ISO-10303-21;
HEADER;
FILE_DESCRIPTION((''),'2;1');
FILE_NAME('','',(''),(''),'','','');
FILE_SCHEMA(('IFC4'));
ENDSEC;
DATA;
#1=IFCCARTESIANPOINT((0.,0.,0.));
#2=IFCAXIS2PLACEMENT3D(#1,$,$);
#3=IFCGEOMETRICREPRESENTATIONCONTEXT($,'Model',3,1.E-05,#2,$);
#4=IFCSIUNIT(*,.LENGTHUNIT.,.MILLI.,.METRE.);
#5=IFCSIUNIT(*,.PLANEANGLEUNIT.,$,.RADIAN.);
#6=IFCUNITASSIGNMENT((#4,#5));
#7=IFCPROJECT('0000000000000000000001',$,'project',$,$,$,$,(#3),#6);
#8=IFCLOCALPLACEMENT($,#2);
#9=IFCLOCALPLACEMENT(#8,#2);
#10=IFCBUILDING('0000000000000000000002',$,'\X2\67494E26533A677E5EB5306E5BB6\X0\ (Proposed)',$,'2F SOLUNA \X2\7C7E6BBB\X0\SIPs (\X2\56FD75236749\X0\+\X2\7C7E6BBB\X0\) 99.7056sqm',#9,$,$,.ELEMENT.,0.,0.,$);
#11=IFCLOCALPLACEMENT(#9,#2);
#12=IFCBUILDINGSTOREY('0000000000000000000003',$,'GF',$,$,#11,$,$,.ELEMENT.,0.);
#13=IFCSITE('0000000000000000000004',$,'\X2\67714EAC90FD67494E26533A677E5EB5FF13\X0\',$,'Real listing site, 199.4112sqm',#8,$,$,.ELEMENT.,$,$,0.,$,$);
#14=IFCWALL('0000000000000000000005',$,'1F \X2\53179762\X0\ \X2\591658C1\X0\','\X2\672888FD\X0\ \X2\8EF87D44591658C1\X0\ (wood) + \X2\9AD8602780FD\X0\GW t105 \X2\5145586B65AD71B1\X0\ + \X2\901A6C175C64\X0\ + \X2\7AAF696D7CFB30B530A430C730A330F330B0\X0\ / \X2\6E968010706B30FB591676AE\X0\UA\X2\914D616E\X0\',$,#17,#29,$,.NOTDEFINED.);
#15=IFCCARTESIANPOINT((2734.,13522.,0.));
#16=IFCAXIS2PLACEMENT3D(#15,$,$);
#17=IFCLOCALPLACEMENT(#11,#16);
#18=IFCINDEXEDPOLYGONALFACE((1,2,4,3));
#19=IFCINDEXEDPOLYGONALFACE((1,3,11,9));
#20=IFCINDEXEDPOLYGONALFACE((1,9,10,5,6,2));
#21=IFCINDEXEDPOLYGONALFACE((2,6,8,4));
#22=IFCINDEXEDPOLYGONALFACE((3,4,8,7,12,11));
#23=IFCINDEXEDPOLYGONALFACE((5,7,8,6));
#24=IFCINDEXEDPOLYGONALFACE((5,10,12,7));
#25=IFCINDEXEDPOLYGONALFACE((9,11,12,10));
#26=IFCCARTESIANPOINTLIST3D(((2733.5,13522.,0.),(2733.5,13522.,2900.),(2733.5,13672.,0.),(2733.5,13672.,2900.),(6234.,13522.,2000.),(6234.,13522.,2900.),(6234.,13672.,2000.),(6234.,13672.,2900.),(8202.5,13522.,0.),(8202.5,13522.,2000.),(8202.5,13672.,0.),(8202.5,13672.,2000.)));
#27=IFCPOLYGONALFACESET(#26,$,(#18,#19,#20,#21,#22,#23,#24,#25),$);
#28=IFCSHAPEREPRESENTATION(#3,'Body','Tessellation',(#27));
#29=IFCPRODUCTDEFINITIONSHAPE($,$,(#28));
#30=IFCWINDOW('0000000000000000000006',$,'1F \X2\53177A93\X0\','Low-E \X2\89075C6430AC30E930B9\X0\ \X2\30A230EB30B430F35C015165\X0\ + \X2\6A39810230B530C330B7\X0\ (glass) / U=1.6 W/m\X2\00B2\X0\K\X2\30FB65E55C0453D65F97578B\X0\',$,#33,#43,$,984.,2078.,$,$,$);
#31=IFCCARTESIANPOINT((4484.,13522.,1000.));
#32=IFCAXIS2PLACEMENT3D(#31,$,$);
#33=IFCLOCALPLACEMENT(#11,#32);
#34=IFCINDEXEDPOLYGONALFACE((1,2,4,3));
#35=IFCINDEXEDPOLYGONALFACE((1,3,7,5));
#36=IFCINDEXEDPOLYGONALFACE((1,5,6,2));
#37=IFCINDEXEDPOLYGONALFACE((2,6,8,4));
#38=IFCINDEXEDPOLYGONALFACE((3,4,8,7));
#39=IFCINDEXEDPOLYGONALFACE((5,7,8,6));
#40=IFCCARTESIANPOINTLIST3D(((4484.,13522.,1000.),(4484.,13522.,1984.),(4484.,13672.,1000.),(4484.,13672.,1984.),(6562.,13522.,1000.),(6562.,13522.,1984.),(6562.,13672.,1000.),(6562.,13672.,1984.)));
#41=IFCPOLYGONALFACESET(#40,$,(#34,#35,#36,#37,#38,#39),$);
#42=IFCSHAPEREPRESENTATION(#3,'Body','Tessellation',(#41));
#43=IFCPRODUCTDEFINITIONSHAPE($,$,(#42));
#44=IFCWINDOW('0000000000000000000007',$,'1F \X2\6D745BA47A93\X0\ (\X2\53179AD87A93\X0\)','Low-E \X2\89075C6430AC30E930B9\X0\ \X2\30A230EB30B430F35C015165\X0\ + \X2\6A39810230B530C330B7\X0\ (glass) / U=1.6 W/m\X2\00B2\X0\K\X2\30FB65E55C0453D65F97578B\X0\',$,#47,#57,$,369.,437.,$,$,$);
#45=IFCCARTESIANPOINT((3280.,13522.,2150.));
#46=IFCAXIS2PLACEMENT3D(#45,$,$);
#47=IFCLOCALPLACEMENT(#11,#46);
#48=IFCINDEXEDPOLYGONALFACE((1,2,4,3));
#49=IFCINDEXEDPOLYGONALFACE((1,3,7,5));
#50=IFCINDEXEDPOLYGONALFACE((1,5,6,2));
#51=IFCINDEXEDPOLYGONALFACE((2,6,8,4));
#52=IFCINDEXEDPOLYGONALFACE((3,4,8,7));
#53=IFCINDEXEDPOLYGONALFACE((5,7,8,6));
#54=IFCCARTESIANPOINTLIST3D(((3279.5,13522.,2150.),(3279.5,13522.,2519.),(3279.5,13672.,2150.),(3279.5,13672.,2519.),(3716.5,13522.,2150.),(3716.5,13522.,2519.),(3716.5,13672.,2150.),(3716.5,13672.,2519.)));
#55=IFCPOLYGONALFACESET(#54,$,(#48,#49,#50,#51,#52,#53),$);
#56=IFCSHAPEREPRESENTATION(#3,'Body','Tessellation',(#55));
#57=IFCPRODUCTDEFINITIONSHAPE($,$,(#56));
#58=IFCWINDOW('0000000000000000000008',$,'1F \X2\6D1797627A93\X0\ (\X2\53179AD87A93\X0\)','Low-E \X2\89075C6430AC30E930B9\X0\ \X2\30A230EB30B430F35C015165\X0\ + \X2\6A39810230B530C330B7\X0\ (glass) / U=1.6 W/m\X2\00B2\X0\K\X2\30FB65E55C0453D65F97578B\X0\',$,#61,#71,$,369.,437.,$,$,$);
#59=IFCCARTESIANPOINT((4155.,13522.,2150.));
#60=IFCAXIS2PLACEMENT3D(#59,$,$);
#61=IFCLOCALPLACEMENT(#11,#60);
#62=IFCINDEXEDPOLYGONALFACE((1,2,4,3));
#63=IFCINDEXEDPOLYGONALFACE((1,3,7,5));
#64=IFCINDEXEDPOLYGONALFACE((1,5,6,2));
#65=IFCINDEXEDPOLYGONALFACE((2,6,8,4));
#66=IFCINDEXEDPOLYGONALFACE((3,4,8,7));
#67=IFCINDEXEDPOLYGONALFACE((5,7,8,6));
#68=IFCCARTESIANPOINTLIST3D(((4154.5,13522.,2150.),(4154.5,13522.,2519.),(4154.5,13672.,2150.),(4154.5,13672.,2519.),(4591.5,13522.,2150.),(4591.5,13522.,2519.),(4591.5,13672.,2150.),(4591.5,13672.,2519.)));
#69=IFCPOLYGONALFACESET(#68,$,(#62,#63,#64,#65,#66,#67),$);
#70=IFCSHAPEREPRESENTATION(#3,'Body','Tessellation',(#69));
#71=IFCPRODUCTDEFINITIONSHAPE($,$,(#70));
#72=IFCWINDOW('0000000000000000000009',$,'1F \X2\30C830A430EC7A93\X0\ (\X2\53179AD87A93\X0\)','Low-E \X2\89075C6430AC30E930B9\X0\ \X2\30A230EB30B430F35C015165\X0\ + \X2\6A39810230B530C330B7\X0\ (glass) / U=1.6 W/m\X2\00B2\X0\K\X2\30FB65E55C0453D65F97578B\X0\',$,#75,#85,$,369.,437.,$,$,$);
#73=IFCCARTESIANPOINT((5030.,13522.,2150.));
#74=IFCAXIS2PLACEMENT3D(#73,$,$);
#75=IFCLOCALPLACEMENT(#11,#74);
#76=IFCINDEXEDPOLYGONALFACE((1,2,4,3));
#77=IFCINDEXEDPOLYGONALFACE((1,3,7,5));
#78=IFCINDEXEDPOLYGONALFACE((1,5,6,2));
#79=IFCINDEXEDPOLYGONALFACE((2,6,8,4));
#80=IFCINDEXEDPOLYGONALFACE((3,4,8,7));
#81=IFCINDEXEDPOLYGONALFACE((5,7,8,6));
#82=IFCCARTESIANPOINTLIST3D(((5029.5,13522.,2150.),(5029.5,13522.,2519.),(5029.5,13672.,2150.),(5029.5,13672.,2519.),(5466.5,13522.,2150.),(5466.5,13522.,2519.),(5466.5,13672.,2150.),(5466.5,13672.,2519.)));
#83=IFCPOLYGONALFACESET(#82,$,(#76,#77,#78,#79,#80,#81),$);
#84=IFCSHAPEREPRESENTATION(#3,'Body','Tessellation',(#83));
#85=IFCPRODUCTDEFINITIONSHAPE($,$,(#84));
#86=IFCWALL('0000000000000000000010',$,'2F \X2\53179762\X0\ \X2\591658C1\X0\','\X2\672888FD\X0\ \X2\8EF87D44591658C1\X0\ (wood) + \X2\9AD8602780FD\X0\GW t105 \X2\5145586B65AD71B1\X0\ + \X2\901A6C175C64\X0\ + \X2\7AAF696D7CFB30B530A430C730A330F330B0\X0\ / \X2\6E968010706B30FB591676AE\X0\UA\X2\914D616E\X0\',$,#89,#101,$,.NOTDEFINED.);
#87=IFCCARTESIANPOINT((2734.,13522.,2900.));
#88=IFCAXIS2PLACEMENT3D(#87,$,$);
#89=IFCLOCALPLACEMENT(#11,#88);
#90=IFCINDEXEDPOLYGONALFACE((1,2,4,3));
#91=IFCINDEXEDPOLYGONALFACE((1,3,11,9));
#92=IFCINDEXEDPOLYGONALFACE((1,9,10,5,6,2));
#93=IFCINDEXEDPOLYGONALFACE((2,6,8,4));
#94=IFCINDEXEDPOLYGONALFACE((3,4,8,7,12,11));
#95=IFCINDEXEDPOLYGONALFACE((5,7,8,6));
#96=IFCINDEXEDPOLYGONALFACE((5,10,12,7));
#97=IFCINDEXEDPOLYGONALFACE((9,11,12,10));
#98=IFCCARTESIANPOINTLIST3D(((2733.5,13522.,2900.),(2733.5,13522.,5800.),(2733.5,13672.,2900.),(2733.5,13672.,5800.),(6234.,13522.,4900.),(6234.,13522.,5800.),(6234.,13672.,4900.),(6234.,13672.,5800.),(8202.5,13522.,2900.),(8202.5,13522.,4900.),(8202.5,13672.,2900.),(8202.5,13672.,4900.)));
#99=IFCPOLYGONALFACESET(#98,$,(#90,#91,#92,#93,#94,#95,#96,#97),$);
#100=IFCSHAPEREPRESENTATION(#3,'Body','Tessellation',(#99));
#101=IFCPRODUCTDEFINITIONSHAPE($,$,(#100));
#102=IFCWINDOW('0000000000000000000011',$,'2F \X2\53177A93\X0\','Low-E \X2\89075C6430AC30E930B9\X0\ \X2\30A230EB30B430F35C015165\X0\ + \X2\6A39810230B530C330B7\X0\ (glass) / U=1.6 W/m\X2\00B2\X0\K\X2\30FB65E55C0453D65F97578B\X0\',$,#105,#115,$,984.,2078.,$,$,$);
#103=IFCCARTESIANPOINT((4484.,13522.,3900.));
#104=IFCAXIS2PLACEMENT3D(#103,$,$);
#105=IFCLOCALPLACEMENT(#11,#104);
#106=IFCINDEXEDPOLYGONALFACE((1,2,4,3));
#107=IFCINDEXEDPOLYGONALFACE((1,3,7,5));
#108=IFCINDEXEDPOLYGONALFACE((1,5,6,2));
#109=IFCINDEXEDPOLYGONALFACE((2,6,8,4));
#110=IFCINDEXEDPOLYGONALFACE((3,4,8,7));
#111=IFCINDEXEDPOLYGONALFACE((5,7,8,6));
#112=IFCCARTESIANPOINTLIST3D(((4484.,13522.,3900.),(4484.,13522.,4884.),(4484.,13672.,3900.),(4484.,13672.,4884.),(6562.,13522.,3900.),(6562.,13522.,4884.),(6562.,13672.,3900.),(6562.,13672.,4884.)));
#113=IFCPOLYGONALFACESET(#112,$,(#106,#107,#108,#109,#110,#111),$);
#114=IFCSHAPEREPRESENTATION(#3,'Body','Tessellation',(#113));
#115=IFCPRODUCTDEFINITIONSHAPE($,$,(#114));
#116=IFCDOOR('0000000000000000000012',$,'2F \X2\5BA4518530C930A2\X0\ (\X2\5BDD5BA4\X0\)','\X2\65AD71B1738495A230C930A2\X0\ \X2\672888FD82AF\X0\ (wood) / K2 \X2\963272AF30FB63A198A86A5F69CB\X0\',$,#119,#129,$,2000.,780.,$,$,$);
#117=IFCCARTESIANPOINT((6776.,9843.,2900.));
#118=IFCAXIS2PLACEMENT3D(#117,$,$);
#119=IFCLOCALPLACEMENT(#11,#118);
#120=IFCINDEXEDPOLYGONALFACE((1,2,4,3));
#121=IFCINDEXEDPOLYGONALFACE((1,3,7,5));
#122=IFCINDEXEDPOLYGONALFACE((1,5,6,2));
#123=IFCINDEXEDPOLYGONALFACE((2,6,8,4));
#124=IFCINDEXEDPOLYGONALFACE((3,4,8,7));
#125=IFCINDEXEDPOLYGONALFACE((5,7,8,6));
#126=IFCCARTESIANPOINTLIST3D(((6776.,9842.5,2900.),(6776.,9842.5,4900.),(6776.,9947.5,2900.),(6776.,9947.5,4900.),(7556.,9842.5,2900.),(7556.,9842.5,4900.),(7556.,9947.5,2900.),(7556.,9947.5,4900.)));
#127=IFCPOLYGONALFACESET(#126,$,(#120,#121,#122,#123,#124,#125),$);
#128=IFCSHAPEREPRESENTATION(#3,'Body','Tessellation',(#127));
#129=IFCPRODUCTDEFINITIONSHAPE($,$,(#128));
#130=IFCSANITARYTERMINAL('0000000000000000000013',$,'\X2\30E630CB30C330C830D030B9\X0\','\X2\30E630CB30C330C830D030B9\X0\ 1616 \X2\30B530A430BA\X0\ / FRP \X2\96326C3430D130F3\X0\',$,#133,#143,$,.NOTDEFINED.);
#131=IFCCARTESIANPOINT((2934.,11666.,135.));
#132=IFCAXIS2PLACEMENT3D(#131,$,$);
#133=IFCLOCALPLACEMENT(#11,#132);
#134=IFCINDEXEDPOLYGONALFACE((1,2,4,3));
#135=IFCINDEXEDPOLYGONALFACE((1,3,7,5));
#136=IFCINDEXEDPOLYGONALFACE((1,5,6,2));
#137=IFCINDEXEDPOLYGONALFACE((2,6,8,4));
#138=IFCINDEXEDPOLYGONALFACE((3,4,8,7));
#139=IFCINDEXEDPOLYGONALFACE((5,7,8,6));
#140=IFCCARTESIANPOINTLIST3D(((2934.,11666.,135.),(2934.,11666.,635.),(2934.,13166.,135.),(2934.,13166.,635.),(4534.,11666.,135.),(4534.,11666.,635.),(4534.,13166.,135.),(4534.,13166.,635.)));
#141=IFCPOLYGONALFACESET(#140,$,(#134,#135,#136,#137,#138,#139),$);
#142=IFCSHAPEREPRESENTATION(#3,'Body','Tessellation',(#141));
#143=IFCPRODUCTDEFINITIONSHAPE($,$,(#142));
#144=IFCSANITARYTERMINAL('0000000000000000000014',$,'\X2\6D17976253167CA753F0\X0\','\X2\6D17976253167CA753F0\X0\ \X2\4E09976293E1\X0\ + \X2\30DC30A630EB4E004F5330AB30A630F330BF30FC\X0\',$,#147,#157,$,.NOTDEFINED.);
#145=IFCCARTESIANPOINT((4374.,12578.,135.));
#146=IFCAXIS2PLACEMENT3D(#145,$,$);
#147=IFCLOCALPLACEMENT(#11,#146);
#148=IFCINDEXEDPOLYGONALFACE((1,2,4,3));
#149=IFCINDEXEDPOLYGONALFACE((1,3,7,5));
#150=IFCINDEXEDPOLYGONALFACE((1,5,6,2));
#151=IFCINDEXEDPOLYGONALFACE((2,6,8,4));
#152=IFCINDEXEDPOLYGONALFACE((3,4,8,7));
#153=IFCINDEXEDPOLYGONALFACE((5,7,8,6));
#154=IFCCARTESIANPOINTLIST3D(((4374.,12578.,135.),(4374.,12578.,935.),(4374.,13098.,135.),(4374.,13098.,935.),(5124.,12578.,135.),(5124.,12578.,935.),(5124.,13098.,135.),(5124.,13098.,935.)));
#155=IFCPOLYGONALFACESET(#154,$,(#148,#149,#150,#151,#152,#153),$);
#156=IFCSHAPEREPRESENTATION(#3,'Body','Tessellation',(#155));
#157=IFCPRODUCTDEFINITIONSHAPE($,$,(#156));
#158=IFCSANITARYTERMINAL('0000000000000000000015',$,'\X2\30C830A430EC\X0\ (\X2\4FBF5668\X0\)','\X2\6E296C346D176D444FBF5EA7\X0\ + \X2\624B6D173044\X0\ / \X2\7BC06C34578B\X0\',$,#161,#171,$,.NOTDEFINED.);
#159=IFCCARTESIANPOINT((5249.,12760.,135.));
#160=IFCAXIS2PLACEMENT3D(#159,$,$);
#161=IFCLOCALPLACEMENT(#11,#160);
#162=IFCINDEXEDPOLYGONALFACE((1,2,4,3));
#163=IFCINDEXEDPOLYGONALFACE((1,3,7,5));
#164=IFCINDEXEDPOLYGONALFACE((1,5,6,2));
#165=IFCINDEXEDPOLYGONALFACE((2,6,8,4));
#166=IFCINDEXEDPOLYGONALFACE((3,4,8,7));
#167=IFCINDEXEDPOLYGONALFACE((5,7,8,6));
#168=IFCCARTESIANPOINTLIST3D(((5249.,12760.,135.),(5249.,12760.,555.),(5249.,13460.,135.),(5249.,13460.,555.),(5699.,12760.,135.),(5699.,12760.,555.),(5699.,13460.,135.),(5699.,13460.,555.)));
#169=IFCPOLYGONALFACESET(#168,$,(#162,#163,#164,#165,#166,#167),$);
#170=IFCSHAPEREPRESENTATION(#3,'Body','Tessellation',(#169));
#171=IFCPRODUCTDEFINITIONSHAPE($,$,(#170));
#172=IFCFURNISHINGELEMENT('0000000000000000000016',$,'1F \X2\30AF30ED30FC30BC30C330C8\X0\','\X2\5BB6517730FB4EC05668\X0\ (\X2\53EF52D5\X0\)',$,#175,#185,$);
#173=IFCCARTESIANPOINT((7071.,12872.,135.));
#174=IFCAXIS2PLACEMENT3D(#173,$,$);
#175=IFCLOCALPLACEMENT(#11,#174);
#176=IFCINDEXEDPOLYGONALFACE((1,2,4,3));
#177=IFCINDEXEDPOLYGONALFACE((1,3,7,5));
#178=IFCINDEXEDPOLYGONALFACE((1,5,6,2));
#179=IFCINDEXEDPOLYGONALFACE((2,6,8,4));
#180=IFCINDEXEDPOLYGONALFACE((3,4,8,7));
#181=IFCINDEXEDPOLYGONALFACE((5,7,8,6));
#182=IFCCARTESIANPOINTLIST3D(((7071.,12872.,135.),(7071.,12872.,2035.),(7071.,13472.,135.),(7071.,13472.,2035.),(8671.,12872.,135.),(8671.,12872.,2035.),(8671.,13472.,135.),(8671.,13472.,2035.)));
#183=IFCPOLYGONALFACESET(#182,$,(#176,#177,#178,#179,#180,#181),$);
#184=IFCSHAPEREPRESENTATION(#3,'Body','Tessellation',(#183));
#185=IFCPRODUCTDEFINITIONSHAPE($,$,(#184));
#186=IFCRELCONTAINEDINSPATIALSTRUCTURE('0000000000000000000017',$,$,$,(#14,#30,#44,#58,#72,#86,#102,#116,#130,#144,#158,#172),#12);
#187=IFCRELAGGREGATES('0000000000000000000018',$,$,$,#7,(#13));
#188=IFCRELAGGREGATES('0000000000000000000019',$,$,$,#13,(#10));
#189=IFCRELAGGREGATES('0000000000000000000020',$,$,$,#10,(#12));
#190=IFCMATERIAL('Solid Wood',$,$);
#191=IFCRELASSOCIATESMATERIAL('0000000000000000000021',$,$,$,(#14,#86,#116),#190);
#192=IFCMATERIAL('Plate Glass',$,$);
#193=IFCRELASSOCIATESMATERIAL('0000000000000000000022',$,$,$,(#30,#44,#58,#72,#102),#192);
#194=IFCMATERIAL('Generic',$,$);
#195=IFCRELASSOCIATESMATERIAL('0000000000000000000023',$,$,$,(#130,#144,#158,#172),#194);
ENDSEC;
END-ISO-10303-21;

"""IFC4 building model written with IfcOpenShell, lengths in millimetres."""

from ifc_helpers import new_model, si_unit, frame, frame_2d, origin, place, context, project, spatial, rectangle, extrude, material, element, fill, save


model = new_model("IFC4")

# Units and contexts
model_context = context("Model", 3, precision=1e-05, world=origin())
ifc_project = project(units=[si_unit("LENGTHUNIT", "METRE", prefix="MILLI"), si_unit("PLANEANGLEUNIT", "RADIAN")], contexts=[model_context])

# Site, building, storey
site_placement = place(None, origin())
site = spatial("IfcSite", under=ifc_project, at=site_placement, Name="東京都杉並区松庵３", ObjectType="Real listing site, 199.4112sqm", CompositionType="ELEMENT", RefElevation=0.0)
building_placement = place(site_placement, origin())
building = spatial("IfcBuilding", under=site, at=building_placement, Name="杉並区松庵の家 (Proposed)", ObjectType="2F SOLUNA 籾殻SIPs (国産杉+籾殻) 99.7056sqm", CompositionType="ELEMENT", ElevationOfRefHeight=0.0, ElevationOfTerrain=0.0)
storey_placement = place(building_placement, origin())
storey = spatial("IfcBuildingStorey", under=building, at=storey_placement, Name="GF", CompositionType="ELEMENT", Elevation=0.0)

# Wall, openings, windows
ifc_material_1 = material(Name="Solid Wood")
wall_1_placement = place(storey_placement, frame((2734.0, 13522.0, 0.0)))
wall_1 = element("IfcWall", 1, at=wall_1_placement, inside=storey, material=ifc_material_1, Name="1F 北面 外壁", Description="木製 軸組外壁 (wood) + 高性能GW t105 充填断熱 + 通気層 + 窯業系サイディング / 準耐火・外皮UA配慮", PredefinedType="NOTDEFINED", context=model_context, shape_type="SweptSolid", body=[
    extrude(rectangle(XDim=5469.0, YDim=150.0, at=frame_2d((2734.0, 75.0))), frame((2734.0, 13522.0, 0.0)), (0.0, 0.0, 1.0), 2900.0),
])
opening_1_placement = place(storey_placement, frame((4484.0, 13522.0, 1000.0)))
opening_1 = element("IfcOpeningElement", 2, at=opening_1_placement, cuts=wall_1, PredefinedType="NOTDEFINED", context=model_context, shape_type="SweptSolid", body=[
    extrude(rectangle(XDim=2078.0, YDim=150.0, at=frame_2d((1039.0, 75.0))), frame((4484.0, 13522.0, 1000.0)), (0.0, 0.0, 1.0), 984.0),
])
opening_2_placement = place(storey_placement, frame((3280.0, 13522.0, 2150.0)))
opening_2 = element("IfcOpeningElement", 3, at=opening_2_placement, cuts=wall_1, PredefinedType="NOTDEFINED", context=model_context, shape_type="SweptSolid", body=[
    extrude(rectangle(XDim=437.0, YDim=150.0, at=frame_2d((218.0, 75.0))), frame((3280.0, 13522.0, 2150.0)), (0.0, 0.0, 1.0), 369.0),
])
opening_3_placement = place(storey_placement, frame((4155.0, 13522.0, 2150.0)))
opening_3 = element("IfcOpeningElement", 4, at=opening_3_placement, cuts=wall_1, PredefinedType="NOTDEFINED", context=model_context, shape_type="SweptSolid", body=[
    extrude(rectangle(XDim=437.0, YDim=150.0, at=frame_2d((218.0, 75.0))), frame((4155.0, 13522.0, 2150.0)), (0.0, 0.0, 1.0), 369.0),
])
opening_4_placement = place(storey_placement, frame((5030.0, 13522.0, 2150.0)))
opening_4 = element("IfcOpeningElement", 5, at=opening_4_placement, cuts=wall_1, PredefinedType="NOTDEFINED", context=model_context, shape_type="SweptSolid", body=[
    extrude(rectangle(XDim=437.0, YDim=150.0, at=frame_2d((218.0, 75.0))), frame((5030.0, 13522.0, 2150.0)), (0.0, 0.0, 1.0), 369.0),
])
ifc_material_2 = material(Name="Plate Glass")
window_1_placement = place(storey_placement, frame((4484.0, 13522.0, 1000.0)))
window_1 = element("IfcWindow", 6, at=window_1_placement, inside=storey, material=ifc_material_2, Name="1F 北窓", Description="Low-E 複層ガラス アルゴン封入 + 樹脂サッシ (glass) / U=1.6 W/m²K・日射取得型", OverallHeight=984.0, OverallWidth=2078.0, context=model_context, shape_type="SweptSolid", body=[
    extrude(rectangle(XDim=2078.0, YDim=150.0, at=frame_2d((1039.0, 75.0))), frame((4484.0, 13522.0, 1000.0)), (0.0, 0.0, 1.0), 984.0),
])
fill(opening_1, window_1)
window_2_placement = place(storey_placement, frame((3280.0, 13522.0, 2150.0)))
window_2 = element("IfcWindow", 7, at=window_2_placement, inside=storey, material=ifc_material_2, Name="1F 浴室窓 (北高窓)", Description="Low-E 複層ガラス アルゴン封入 + 樹脂サッシ (glass) / U=1.6 W/m²K・日射取得型", OverallHeight=369.0, OverallWidth=437.0, context=model_context, shape_type="SweptSolid", body=[
    extrude(rectangle(XDim=437.0, YDim=150.0, at=frame_2d((218.0, 75.0))), frame((3280.0, 13522.0, 2150.0)), (0.0, 0.0, 1.0), 369.0),
])
fill(opening_2, window_2)
window_3_placement = place(storey_placement, frame((4155.0, 13522.0, 2150.0)))
window_3 = element("IfcWindow", 8, at=window_3_placement, inside=storey, material=ifc_material_2, Name="1F 洗面窓 (北高窓)", Description="Low-E 複層ガラス アルゴン封入 + 樹脂サッシ (glass) / U=1.6 W/m²K・日射取得型", OverallHeight=369.0, OverallWidth=437.0, context=model_context, shape_type="SweptSolid", body=[
    extrude(rectangle(XDim=437.0, YDim=150.0, at=frame_2d((218.0, 75.0))), frame((4155.0, 13522.0, 2150.0)), (0.0, 0.0, 1.0), 369.0),
])
fill(opening_3, window_3)
window_4_placement = place(storey_placement, frame((5030.0, 13522.0, 2150.0)))
window_4 = element("IfcWindow", 9, at=window_4_placement, inside=storey, material=ifc_material_2, Name="1F トイレ窓 (北高窓)", Description="Low-E 複層ガラス アルゴン封入 + 樹脂サッシ (glass) / U=1.6 W/m²K・日射取得型", OverallHeight=369.0, OverallWidth=437.0, context=model_context, shape_type="SweptSolid", body=[
    extrude(rectangle(XDim=437.0, YDim=150.0, at=frame_2d((218.0, 75.0))), frame((5030.0, 13522.0, 2150.0)), (0.0, 0.0, 1.0), 369.0),
])
fill(opening_4, window_4)

# Wall, opening, window
wall_2_placement = place(storey_placement, frame((2734.0, 13522.0, 2900.0)))
wall_2 = element("IfcWall", 10, at=wall_2_placement, inside=storey, material=ifc_material_1, Name="2F 北面 外壁", Description="木製 軸組外壁 (wood) + 高性能GW t105 充填断熱 + 通気層 + 窯業系サイディング / 準耐火・外皮UA配慮", PredefinedType="NOTDEFINED", context=model_context, shape_type="SweptSolid", body=[
    extrude(rectangle(XDim=5469.0, YDim=150.0, at=frame_2d((2734.0, 75.0))), frame((2734.0, 13522.0, 2900.0)), (0.0, 0.0, 1.0), 2900.0),
])
opening_5_placement = place(storey_placement, frame((4484.0, 13522.0, 3900.0)))
opening_5 = element("IfcOpeningElement", 11, at=opening_5_placement, cuts=wall_2, PredefinedType="NOTDEFINED", context=model_context, shape_type="SweptSolid", body=[
    extrude(rectangle(XDim=2078.0, YDim=150.0, at=frame_2d((1039.0, 75.0))), frame((4484.0, 13522.0, 3900.0)), (0.0, 0.0, 1.0), 984.0),
])
window_5_placement = place(storey_placement, frame((4484.0, 13522.0, 3900.0)))
window_5 = element("IfcWindow", 12, at=window_5_placement, inside=storey, material=ifc_material_2, Name="2F 北窓", Description="Low-E 複層ガラス アルゴン封入 + 樹脂サッシ (glass) / U=1.6 W/m²K・日射取得型", OverallHeight=984.0, OverallWidth=2078.0, context=model_context, shape_type="SweptSolid", body=[
    extrude(rectangle(XDim=2078.0, YDim=150.0, at=frame_2d((1039.0, 75.0))), frame((4484.0, 13522.0, 3900.0)), (0.0, 0.0, 1.0), 984.0),
])
fill(opening_5, window_5)

# Door
door_1_placement = place(storey_placement, frame((6776.0, 9843.0, 2900.0)))
element("IfcDoor", 13, at=door_1_placement, inside=storey, material=ifc_material_1, Name="2F 室内ドア (寝室)", Description="断熱玄関ドア 木製芯 (wood) / K2 防犯・採風機構", OverallHeight=2000.0, OverallWidth=780.0, context=model_context, shape_type="SweptSolid", body=[
    extrude(rectangle(XDim=780.0, YDim=105.0, at=frame_2d((390.0, 52.0))), frame((6776.0, 9843.0, 2900.0)), (0.0, 0.0, 1.0), 2000.0),
])

# Sanitary terminals
ifc_material_3 = material(Name="Generic")
sanitary_terminal_1_placement = place(storey_placement, frame((2934.0, 11666.0, 135.0)))
element("IfcSanitaryTerminal", 14, at=sanitary_terminal_1_placement, inside=storey, material=ifc_material_3, Name="ユニットバス", Description="ユニットバス 1616 サイズ / FRP 防水パン", PredefinedType="NOTDEFINED", context=model_context, shape_type="SweptSolid", body=[
    extrude(rectangle(XDim=1600.0, YDim=1500.0, at=frame_2d((800.0, 750.0))), frame((2934.0, 11666.0, 135.0)), (0.0, 0.0, 1.0), 500.0),
])
sanitary_terminal_2_placement = place(storey_placement, frame((4374.0, 12578.0, 135.0)))
element("IfcSanitaryTerminal", 15, at=sanitary_terminal_2_placement, inside=storey, material=ifc_material_3, Name="洗面化粧台", Description="洗面化粧台 三面鏡 + ボウル一体カウンター", PredefinedType="NOTDEFINED", context=model_context, shape_type="SweptSolid", body=[
    extrude(rectangle(XDim=750.0, YDim=520.0, at=frame_2d((375.0, 260.0))), frame((4374.0, 12578.0, 135.0)), (0.0, 0.0, 1.0), 800.0),
])
sanitary_terminal_3_placement = place(storey_placement, frame((5249.0, 12760.0, 135.0)))
element("IfcSanitaryTerminal", 16, at=sanitary_terminal_3_placement, inside=storey, material=ifc_material_3, Name="トイレ (便器)", Description="温水洗浄便座 + 手洗い / 節水型", PredefinedType="NOTDEFINED", context=model_context, shape_type="SweptSolid", body=[
    extrude(rectangle(XDim=450.0, YDim=700.0, at=frame_2d((225.0, 350.0))), frame((5249.0, 12760.0, 135.0)), (0.0, 0.0, 1.0), 420.0),
])

# Furnishing element
furnishing_1_placement = place(storey_placement, frame((7071.0, 12872.0, 135.0)))
element("IfcFurnishingElement", 17, at=furnishing_1_placement, inside=storey, material=ifc_material_3, Name="1F クローゼット", Description="家具・什器 (可動)", context=model_context, shape_type="SweptSolid", body=[
    extrude(rectangle(XDim=1600.0, YDim=600.0, at=frame_2d((800.0, 300.0))), frame((7071.0, 12872.0, 135.0)), (0.0, 0.0, 1.0), 1900.0),
])

save(model, "model.ifc")
